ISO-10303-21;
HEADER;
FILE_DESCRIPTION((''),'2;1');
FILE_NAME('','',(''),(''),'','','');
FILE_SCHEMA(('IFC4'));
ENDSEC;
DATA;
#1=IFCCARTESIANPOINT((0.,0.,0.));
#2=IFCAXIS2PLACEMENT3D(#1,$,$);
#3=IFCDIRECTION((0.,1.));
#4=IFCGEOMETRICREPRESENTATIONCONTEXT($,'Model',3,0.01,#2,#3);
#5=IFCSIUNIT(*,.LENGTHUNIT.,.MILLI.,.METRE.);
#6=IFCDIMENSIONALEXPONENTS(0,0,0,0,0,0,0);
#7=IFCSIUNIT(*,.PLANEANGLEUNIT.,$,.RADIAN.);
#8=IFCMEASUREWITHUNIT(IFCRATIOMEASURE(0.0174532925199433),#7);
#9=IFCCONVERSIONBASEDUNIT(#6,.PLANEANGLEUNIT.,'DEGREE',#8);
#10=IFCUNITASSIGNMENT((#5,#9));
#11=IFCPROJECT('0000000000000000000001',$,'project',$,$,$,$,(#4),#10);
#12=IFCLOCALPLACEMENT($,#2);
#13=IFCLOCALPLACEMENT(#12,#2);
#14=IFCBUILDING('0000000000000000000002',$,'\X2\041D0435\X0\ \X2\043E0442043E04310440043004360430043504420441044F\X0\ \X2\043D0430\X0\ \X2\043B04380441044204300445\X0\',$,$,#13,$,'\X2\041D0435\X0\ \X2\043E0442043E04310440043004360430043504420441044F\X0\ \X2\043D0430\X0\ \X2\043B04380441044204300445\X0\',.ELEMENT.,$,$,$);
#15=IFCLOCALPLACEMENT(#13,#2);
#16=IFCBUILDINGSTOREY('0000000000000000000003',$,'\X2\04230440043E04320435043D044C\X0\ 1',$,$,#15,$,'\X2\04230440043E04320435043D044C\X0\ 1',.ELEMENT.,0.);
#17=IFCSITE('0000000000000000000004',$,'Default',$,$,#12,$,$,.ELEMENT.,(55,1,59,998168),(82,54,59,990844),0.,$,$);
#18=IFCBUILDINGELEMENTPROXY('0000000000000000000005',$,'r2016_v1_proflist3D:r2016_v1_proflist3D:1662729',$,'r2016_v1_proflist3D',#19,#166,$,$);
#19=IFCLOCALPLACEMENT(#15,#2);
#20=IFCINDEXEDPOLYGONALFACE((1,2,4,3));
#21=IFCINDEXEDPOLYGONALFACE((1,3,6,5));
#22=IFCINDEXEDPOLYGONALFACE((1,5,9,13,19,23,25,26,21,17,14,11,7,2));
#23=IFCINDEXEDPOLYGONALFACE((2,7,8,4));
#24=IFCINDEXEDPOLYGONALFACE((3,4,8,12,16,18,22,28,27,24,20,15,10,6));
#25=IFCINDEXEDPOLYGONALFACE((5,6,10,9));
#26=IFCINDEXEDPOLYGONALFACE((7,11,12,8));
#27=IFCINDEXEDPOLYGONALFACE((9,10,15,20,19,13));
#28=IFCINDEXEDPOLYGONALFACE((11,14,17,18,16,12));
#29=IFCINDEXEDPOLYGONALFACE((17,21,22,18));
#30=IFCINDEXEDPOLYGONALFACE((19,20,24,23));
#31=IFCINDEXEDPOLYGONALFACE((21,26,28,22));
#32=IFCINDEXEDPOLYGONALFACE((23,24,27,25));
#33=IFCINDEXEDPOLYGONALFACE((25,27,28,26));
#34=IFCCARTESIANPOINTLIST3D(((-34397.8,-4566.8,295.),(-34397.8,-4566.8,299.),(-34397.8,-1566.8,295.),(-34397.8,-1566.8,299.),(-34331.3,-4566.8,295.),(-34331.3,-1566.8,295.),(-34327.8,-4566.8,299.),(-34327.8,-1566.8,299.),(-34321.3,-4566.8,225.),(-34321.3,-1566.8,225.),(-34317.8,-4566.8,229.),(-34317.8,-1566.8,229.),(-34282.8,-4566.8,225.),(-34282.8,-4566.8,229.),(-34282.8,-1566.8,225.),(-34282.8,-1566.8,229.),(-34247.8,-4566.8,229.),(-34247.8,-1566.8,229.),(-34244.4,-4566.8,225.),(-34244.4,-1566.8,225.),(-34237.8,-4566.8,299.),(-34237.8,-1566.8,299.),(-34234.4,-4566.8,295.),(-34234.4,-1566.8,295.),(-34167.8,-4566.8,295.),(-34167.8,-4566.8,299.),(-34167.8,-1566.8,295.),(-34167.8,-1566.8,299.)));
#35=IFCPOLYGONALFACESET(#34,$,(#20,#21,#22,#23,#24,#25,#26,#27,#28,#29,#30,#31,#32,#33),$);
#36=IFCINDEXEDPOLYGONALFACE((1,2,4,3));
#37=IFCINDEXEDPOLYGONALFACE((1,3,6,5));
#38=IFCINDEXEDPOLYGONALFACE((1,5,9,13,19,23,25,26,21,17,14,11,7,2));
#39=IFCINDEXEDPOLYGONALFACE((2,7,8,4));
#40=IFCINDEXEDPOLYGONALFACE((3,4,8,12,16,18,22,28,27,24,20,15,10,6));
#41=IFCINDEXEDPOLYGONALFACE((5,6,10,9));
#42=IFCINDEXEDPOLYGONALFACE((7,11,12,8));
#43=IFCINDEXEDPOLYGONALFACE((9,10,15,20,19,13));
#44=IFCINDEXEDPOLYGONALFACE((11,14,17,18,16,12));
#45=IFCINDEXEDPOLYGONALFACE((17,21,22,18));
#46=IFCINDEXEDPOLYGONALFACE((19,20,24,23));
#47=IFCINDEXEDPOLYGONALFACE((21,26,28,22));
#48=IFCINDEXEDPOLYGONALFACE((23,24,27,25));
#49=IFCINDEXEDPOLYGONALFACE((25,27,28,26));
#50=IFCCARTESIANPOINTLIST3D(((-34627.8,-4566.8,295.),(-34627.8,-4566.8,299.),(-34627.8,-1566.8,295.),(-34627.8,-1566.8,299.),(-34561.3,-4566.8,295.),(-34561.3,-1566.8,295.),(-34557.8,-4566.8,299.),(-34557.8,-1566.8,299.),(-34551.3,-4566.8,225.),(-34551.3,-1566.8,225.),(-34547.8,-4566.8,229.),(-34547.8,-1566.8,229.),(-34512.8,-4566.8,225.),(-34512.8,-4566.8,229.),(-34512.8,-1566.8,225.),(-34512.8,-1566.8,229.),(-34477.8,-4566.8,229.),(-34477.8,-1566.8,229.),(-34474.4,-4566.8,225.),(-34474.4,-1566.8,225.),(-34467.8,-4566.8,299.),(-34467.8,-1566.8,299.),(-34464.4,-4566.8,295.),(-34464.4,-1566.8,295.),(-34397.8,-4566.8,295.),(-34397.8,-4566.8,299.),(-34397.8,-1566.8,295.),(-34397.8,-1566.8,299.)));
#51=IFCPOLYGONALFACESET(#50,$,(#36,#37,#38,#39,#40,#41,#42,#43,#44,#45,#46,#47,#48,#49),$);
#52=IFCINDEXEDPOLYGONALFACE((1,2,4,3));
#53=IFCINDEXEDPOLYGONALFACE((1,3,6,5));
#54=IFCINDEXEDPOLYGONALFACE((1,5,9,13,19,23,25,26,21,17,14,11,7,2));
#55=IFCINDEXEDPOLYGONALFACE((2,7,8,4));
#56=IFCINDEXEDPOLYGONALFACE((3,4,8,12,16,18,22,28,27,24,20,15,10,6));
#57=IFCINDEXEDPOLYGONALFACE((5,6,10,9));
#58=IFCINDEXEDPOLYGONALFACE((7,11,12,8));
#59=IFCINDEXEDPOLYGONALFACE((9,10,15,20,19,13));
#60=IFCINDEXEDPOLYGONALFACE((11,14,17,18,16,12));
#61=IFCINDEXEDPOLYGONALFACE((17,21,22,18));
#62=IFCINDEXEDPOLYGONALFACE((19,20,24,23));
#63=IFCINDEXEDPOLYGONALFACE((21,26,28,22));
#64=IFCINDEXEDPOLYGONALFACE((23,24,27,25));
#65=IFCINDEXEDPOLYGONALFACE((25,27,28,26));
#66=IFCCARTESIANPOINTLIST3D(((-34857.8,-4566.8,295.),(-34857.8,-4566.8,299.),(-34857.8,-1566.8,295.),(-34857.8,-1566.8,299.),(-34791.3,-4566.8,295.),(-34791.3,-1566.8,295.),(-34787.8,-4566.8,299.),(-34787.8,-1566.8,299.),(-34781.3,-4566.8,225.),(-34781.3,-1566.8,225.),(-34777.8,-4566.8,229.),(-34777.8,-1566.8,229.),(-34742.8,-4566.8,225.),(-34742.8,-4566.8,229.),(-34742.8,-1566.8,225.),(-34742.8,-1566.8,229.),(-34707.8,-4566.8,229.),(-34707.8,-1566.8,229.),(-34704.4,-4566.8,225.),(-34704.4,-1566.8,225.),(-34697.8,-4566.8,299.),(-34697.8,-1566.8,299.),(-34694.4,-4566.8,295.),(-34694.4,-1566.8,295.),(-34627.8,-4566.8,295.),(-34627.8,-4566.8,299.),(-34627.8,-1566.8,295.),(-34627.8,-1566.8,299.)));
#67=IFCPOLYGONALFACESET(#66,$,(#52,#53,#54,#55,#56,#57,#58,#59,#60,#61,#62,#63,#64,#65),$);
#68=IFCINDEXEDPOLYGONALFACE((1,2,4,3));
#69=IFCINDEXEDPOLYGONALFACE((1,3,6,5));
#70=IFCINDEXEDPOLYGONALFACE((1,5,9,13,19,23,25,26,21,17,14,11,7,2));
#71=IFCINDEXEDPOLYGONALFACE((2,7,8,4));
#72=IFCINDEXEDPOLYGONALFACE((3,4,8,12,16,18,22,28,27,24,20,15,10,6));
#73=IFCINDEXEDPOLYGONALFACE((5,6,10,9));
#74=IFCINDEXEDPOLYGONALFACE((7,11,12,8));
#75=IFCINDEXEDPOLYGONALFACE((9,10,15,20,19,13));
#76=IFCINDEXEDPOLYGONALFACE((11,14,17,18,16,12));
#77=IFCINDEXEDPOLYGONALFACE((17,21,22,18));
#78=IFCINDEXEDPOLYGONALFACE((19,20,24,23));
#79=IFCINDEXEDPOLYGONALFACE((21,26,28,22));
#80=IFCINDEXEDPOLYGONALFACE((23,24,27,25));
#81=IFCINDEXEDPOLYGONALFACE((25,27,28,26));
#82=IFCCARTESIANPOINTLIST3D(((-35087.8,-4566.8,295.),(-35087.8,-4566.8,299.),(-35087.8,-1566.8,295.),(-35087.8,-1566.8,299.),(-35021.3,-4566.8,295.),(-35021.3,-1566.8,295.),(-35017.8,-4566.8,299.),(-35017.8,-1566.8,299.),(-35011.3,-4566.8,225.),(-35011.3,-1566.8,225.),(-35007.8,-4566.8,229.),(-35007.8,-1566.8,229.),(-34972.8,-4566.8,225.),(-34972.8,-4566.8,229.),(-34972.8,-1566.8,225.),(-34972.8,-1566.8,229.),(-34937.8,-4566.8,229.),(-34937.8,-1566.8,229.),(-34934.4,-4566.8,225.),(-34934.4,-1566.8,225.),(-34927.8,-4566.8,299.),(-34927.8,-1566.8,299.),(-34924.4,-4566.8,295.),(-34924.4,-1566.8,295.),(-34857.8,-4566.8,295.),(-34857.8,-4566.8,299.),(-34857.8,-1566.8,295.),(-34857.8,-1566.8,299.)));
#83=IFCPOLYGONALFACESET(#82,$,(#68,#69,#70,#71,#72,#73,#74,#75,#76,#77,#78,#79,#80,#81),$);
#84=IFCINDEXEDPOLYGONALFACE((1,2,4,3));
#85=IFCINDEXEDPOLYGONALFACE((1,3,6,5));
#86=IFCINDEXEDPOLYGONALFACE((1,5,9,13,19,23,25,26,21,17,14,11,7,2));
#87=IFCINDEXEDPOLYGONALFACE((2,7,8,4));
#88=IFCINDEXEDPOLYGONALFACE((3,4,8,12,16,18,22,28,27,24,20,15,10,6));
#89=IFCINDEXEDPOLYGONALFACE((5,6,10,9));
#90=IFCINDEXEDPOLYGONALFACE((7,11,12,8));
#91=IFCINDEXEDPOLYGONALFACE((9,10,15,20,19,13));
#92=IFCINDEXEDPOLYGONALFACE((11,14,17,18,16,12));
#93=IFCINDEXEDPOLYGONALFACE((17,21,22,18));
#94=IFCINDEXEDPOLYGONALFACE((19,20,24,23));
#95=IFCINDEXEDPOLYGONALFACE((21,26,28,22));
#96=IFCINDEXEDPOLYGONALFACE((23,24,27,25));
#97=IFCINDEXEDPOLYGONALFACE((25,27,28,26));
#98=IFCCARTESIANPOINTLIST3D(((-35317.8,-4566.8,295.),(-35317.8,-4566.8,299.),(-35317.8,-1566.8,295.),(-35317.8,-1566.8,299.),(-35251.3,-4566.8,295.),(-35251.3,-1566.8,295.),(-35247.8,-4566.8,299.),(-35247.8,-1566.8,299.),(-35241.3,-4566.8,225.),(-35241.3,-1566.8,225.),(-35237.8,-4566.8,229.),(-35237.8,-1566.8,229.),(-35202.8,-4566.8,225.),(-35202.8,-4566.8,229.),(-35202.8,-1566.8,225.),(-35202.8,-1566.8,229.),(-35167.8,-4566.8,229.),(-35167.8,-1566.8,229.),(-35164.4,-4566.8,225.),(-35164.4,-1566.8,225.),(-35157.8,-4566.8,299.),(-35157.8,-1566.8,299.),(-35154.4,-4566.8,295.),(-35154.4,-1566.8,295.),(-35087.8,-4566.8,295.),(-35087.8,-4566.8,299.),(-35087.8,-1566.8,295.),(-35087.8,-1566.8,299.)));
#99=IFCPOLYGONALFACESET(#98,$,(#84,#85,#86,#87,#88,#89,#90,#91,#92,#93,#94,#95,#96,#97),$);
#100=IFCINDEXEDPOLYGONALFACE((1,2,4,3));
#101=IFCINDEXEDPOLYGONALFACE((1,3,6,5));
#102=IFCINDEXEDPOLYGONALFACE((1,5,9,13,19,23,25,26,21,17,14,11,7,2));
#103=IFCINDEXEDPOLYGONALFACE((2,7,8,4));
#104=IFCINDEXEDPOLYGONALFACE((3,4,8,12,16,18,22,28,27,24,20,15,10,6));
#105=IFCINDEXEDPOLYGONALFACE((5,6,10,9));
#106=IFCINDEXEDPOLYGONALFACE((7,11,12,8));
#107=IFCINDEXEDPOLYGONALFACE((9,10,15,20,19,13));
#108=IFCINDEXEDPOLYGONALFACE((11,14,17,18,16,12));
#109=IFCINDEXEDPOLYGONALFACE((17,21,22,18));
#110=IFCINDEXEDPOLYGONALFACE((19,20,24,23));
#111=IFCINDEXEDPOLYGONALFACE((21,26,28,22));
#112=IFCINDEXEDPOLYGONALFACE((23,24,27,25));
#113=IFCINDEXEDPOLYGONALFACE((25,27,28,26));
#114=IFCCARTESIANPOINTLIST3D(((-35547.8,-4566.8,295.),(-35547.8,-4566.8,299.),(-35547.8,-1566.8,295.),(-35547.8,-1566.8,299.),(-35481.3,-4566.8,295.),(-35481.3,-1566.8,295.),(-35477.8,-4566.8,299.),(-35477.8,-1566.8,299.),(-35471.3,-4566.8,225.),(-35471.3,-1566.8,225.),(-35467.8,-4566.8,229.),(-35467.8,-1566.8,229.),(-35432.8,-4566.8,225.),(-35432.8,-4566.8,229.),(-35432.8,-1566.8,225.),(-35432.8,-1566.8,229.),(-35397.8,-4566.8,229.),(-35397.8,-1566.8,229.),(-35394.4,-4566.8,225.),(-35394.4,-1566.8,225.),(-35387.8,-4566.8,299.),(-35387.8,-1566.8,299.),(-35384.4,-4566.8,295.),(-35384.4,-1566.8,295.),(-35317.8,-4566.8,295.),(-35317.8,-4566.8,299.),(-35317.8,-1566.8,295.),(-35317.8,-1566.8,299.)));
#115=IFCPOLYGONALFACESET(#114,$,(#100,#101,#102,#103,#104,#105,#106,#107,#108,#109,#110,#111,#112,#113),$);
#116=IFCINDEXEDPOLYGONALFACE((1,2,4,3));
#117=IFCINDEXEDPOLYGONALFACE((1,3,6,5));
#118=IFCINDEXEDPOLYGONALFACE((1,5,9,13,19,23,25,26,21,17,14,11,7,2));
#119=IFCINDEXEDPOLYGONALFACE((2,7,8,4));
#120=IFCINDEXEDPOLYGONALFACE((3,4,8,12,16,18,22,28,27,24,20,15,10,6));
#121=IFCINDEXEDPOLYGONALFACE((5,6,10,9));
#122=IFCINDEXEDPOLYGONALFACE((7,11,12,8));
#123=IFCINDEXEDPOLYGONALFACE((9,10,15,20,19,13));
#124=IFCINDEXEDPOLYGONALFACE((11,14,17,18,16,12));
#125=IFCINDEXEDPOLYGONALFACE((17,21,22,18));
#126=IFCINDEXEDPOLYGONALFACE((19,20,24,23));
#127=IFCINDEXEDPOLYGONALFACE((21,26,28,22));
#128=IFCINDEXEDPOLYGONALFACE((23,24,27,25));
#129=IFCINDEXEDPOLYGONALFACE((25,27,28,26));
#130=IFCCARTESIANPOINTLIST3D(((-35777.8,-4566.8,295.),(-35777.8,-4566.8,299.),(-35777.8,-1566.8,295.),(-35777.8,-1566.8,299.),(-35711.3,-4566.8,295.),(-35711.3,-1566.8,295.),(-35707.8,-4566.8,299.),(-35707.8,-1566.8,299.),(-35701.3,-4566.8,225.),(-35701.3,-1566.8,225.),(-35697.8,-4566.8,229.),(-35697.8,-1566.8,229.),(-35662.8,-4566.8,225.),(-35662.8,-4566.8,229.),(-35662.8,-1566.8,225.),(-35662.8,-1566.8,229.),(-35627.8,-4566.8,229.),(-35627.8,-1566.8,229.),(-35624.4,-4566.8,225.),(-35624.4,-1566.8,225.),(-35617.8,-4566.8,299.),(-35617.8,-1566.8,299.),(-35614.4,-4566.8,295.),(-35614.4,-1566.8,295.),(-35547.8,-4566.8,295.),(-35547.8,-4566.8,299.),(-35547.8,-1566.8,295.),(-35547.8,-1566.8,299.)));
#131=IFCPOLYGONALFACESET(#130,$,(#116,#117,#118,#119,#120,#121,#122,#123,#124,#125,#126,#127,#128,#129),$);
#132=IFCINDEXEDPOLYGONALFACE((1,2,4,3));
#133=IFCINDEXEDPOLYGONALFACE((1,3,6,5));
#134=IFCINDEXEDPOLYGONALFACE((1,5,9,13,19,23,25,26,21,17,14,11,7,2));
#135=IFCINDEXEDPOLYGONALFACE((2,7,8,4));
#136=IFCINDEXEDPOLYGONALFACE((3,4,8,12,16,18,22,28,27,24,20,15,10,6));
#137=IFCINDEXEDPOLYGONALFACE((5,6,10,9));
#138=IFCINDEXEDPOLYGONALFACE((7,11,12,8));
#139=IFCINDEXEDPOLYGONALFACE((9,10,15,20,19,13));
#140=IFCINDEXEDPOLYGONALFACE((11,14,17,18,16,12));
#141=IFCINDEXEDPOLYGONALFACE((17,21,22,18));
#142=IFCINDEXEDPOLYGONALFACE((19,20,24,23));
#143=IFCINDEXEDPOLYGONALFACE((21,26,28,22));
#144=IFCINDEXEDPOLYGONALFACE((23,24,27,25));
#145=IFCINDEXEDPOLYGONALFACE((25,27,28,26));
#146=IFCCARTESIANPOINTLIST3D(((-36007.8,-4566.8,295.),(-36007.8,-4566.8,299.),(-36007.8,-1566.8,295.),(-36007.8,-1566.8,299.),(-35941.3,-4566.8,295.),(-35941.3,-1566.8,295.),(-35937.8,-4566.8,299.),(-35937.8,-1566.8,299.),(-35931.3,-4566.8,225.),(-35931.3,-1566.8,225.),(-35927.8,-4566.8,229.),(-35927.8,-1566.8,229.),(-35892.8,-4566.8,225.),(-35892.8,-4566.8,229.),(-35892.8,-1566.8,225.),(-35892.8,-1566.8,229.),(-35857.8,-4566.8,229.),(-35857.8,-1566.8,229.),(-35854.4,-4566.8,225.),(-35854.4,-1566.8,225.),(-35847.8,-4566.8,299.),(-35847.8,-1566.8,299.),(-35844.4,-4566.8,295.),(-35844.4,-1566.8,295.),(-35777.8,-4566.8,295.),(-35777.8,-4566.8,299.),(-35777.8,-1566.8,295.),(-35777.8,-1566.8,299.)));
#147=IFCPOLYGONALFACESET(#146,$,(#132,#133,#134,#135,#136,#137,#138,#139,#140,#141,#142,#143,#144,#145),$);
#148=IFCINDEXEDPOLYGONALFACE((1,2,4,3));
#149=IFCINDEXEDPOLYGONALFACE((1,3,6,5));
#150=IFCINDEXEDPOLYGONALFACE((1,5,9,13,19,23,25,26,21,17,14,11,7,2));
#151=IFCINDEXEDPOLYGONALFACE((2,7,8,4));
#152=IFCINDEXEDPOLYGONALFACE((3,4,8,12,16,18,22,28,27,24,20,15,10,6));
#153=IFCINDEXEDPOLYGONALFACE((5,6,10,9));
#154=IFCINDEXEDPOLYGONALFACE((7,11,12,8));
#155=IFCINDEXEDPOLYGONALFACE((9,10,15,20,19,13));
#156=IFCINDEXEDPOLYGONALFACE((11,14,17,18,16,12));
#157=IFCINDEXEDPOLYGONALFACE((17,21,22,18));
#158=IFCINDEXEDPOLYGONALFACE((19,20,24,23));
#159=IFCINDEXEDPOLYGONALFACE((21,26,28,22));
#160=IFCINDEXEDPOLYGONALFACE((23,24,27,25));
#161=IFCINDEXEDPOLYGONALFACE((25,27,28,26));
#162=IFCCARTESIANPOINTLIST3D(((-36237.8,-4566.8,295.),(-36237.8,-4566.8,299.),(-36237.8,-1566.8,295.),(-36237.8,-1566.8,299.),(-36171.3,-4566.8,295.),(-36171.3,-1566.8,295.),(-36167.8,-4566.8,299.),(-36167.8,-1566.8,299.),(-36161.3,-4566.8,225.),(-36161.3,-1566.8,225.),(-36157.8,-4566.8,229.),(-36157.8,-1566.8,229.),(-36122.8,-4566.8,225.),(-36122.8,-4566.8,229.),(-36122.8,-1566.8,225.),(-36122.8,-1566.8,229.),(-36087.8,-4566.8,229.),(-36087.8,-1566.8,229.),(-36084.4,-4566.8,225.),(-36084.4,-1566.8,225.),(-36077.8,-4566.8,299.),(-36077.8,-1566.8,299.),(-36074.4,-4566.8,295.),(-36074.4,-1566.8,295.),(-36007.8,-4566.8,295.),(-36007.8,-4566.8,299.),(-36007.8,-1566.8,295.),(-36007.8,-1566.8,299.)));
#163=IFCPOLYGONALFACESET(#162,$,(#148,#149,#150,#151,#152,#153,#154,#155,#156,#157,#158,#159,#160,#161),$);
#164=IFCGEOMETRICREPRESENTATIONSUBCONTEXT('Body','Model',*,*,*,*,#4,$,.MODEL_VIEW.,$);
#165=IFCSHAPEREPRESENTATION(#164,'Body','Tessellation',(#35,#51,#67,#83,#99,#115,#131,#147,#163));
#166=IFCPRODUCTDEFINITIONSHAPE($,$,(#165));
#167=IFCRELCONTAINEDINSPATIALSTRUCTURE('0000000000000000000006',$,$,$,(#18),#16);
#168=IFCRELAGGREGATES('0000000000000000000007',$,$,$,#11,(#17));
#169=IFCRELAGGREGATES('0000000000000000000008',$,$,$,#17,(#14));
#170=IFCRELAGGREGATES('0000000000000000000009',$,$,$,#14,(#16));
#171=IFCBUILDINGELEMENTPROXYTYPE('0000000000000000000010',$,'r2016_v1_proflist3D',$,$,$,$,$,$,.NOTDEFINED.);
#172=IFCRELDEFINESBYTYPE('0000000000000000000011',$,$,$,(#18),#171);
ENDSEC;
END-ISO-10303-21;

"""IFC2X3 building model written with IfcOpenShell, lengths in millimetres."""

from ifc_helpers import new_model, entity, si_unit, converted_unit, direction, frame, origin, place, context, subcontext, project, spatial, polyline, outline, extrude, source, transform, mapped, type_object, type_shapes, element, save


model = new_model("IFC2X3")

# Units and contexts
model_context = context("Model", 3, precision=0.01, world=origin(), true_north=direction((0.0, 1.0)))
body_context = subcontext(model_context, "Body", "Model", "MODEL_VIEW")
ifc_project = project(units=[si_unit("LENGTHUNIT", "METRE", prefix="MILLI"), converted_unit("PLANEANGLEUNIT", "DEGREE", entity("IfcRatioMeasure", 0.0174532925199433), si_unit("PLANEANGLEUNIT", "RADIAN"), dimensions=[0, 0, 0, 0, 0, 0, 0])], contexts=[model_context])

# Site, building, storey
site_placement = place(None, origin())
site = spatial("IfcSite", under=ifc_project, at=site_placement, Name="Default", CompositionType="ELEMENT", RefLatitude=(55, 1, 59, 998168), RefLongitude=(82, 54, 59, 990844), RefElevation=0.0)
building_placement = place(site_placement, origin())
building = spatial("IfcBuilding", under=site, at=building_placement, Name="Не отображается на листах", LongName="Не отображается на листах", CompositionType="ELEMENT")
storey_placement = place(building_placement, frame((0.0, 0.0, 0.0)))
storey = spatial("IfcBuildingStorey", under=building, at=storey_placement, Name="Уровень 1", LongName="Уровень 1", CompositionType="ELEMENT", Elevation=0.0)

# Building element proxy
building_element_proxy_type = type_object("IfcBuildingElementProxyType", Name="r2016_v1_proflist3D", PredefinedType="NOTDEFINED")
shared_shape = source(origin(), body_context, "Body", "SweptSolid", [
    extrude(outline(polyline([(-38.0, -40.0), (-47.9, -109.3), (-44.0, -109.9), (-34.6, -44.0), (36.1, -44.0), (41.6, -5.9), (47.0, 32.1), (-20.9, 51.9), (-11.5, 117.8), (-15.4, 118.4), (-25.3, 49.1), (42.6, 29.3), (37.6, -5.4), (32.7, -40.0), (-38.0, -40.0)])), frame((1955.0, -3000.0, -32.0), z_axis=(0.0, -1.0, 0.0), x_axis=(0.141421, 0.0, -0.989949)), (0.0, 0.0, -1.0), 3000.0),
    extrude(outline(polyline([(-38.0, -40.0), (-47.9, -109.3), (-44.0, -109.9), (-34.6, -44.0), (36.1, -44.0), (41.6, -5.9), (47.0, 32.1), (-20.9, 51.9), (-11.5, 117.8), (-15.4, 118.4), (-25.3, 49.1), (42.6, 29.3), (37.6, -5.4), (32.7, -40.0), (-38.0, -40.0)])), frame((1725.0, -3000.0, -32.0), z_axis=(0.0, -1.0, 0.0), x_axis=(0.141421, 0.0, -0.989949)), (0.0, 0.0, -1.0), 3000.0),
    extrude(outline(polyline([(-38.0, -40.0), (-47.9, -109.3), (-44.0, -109.9), (-34.6, -44.0), (36.1, -44.0), (41.6, -5.9), (47.0, 32.1), (-20.9, 51.9), (-11.5, 117.8), (-15.4, 118.4), (-25.3, 49.1), (42.6, 29.3), (37.6, -5.4), (32.7, -40.0), (-38.0, -40.0)])), frame((1495.0, -3000.0, -32.0), z_axis=(0.0, -1.0, 0.0), x_axis=(0.141421, 0.0, -0.989949)), (0.0, 0.0, -1.0), 3000.0),
    extrude(outline(polyline([(-38.0, -40.0), (-47.9, -109.3), (-44.0, -109.9), (-34.6, -44.0), (36.1, -44.0), (41.6, -5.9), (47.0, 32.1), (-20.9, 51.9), (-11.5, 117.8), (-15.4, 118.4), (-25.3, 49.1), (42.6, 29.3), (37.6, -5.4), (32.7, -40.0), (-38.0, -40.0)])), frame((1265.0, -3000.0, -32.0), z_axis=(0.0, -1.0, 0.0), x_axis=(0.141421, 0.0, -0.989949)), (0.0, 0.0, -1.0), 3000.0),
    extrude(outline(polyline([(-38.0, -40.0), (-47.9, -109.3), (-44.0, -109.9), (-34.6, -44.0), (36.1, -44.0), (41.6, -5.9), (47.0, 32.1), (-20.9, 51.9), (-11.5, 117.8), (-15.4, 118.4), (-25.3, 49.1), (42.6, 29.3), (37.6, -5.4), (32.7, -40.0), (-38.0, -40.0)])), frame((1035.0, -3000.0, -32.0), z_axis=(0.0, -1.0, 0.0), x_axis=(0.141421, 0.0, -0.989949)), (0.0, 0.0, -1.0), 3000.0),
    extrude(outline(polyline([(-38.0, -40.0), (-47.9, -109.3), (-44.0, -109.9), (-34.6, -44.0), (36.1, -44.0), (41.6, -5.9), (47.0, 32.1), (-20.9, 51.9), (-11.5, 117.8), (-15.4, 118.4), (-25.3, 49.1), (42.6, 29.3), (37.6, -5.4), (32.7, -40.0), (-38.0, -40.0)])), frame((805.0, -3000.0, -32.0), z_axis=(0.0, -1.0, 0.0), x_axis=(0.141421, 0.0, -0.989949)), (0.0, 0.0, -1.0), 3000.0),
    extrude(outline(polyline([(-38.0, -40.0), (-47.9, -109.3), (-44.0, -109.9), (-34.6, -44.0), (36.1, -44.0), (41.6, -5.9), (47.0, 32.1), (-20.9, 51.9), (-11.5, 117.8), (-15.4, 118.4), (-25.3, 49.1), (42.6, 29.3), (37.6, -5.4), (32.7, -40.0), (-38.0, -40.0)])), frame((575.0, -3000.0, -32.0), z_axis=(0.0, -1.0, 0.0), x_axis=(0.141421, 0.0, -0.989949)), (0.0, 0.0, -1.0), 3000.0),
    extrude(outline(polyline([(-38.0, -40.0), (-47.9, -109.3), (-44.0, -109.9), (-34.6, -44.0), (36.1, -44.0), (41.6, -5.9), (47.0, 32.1), (-20.9, 51.9), (-11.5, 117.8), (-15.4, 118.4), (-25.3, 49.1), (42.6, 29.3), (37.6, -5.4), (32.7, -40.0), (-38.0, -40.0)])), frame((345.0, -3000.0, -32.0), z_axis=(0.0, -1.0, 0.0), x_axis=(0.141421, 0.0, -0.989949)), (0.0, 0.0, -1.0), 3000.0),
    extrude(outline(polyline([(-38.0, -40.0), (-47.9, -109.3), (-44.0, -109.9), (-34.6, -44.0), (36.1, -44.0), (41.6, -5.9), (47.0, 32.1), (-20.9, 51.9), (-11.5, 117.8), (-15.4, 118.4), (-25.3, 49.1), (42.6, 29.3), (37.6, -5.4), (32.7, -40.0), (-38.0, -40.0)])), frame((115.0, -3000.0, -32.0), z_axis=(0.0, -1.0, 0.0), x_axis=(0.141421, 0.0, -0.989949)), (0.0, 0.0, -1.0), 3000.0),
])
type_shapes(building_element_proxy_type, [shared_shape])
proxy_1_placement = place(storey_placement, frame((-36237.8, -1566.8, 299.0)))
element("IfcBuildingElementProxy", 1, at=proxy_1_placement, inside=storey, type_object=building_element_proxy_type, Name="r2016_v1_proflist3D:r2016_v1_proflist3D:1662729", ObjectType="r2016_v1_proflist3D", context=body_context, shape_type="MappedRepresentation", body=[
    mapped(shared_shape, transform((0.0, 0.0, 0.0), scale=1.0)),
])

save(model, "model.ifc")
